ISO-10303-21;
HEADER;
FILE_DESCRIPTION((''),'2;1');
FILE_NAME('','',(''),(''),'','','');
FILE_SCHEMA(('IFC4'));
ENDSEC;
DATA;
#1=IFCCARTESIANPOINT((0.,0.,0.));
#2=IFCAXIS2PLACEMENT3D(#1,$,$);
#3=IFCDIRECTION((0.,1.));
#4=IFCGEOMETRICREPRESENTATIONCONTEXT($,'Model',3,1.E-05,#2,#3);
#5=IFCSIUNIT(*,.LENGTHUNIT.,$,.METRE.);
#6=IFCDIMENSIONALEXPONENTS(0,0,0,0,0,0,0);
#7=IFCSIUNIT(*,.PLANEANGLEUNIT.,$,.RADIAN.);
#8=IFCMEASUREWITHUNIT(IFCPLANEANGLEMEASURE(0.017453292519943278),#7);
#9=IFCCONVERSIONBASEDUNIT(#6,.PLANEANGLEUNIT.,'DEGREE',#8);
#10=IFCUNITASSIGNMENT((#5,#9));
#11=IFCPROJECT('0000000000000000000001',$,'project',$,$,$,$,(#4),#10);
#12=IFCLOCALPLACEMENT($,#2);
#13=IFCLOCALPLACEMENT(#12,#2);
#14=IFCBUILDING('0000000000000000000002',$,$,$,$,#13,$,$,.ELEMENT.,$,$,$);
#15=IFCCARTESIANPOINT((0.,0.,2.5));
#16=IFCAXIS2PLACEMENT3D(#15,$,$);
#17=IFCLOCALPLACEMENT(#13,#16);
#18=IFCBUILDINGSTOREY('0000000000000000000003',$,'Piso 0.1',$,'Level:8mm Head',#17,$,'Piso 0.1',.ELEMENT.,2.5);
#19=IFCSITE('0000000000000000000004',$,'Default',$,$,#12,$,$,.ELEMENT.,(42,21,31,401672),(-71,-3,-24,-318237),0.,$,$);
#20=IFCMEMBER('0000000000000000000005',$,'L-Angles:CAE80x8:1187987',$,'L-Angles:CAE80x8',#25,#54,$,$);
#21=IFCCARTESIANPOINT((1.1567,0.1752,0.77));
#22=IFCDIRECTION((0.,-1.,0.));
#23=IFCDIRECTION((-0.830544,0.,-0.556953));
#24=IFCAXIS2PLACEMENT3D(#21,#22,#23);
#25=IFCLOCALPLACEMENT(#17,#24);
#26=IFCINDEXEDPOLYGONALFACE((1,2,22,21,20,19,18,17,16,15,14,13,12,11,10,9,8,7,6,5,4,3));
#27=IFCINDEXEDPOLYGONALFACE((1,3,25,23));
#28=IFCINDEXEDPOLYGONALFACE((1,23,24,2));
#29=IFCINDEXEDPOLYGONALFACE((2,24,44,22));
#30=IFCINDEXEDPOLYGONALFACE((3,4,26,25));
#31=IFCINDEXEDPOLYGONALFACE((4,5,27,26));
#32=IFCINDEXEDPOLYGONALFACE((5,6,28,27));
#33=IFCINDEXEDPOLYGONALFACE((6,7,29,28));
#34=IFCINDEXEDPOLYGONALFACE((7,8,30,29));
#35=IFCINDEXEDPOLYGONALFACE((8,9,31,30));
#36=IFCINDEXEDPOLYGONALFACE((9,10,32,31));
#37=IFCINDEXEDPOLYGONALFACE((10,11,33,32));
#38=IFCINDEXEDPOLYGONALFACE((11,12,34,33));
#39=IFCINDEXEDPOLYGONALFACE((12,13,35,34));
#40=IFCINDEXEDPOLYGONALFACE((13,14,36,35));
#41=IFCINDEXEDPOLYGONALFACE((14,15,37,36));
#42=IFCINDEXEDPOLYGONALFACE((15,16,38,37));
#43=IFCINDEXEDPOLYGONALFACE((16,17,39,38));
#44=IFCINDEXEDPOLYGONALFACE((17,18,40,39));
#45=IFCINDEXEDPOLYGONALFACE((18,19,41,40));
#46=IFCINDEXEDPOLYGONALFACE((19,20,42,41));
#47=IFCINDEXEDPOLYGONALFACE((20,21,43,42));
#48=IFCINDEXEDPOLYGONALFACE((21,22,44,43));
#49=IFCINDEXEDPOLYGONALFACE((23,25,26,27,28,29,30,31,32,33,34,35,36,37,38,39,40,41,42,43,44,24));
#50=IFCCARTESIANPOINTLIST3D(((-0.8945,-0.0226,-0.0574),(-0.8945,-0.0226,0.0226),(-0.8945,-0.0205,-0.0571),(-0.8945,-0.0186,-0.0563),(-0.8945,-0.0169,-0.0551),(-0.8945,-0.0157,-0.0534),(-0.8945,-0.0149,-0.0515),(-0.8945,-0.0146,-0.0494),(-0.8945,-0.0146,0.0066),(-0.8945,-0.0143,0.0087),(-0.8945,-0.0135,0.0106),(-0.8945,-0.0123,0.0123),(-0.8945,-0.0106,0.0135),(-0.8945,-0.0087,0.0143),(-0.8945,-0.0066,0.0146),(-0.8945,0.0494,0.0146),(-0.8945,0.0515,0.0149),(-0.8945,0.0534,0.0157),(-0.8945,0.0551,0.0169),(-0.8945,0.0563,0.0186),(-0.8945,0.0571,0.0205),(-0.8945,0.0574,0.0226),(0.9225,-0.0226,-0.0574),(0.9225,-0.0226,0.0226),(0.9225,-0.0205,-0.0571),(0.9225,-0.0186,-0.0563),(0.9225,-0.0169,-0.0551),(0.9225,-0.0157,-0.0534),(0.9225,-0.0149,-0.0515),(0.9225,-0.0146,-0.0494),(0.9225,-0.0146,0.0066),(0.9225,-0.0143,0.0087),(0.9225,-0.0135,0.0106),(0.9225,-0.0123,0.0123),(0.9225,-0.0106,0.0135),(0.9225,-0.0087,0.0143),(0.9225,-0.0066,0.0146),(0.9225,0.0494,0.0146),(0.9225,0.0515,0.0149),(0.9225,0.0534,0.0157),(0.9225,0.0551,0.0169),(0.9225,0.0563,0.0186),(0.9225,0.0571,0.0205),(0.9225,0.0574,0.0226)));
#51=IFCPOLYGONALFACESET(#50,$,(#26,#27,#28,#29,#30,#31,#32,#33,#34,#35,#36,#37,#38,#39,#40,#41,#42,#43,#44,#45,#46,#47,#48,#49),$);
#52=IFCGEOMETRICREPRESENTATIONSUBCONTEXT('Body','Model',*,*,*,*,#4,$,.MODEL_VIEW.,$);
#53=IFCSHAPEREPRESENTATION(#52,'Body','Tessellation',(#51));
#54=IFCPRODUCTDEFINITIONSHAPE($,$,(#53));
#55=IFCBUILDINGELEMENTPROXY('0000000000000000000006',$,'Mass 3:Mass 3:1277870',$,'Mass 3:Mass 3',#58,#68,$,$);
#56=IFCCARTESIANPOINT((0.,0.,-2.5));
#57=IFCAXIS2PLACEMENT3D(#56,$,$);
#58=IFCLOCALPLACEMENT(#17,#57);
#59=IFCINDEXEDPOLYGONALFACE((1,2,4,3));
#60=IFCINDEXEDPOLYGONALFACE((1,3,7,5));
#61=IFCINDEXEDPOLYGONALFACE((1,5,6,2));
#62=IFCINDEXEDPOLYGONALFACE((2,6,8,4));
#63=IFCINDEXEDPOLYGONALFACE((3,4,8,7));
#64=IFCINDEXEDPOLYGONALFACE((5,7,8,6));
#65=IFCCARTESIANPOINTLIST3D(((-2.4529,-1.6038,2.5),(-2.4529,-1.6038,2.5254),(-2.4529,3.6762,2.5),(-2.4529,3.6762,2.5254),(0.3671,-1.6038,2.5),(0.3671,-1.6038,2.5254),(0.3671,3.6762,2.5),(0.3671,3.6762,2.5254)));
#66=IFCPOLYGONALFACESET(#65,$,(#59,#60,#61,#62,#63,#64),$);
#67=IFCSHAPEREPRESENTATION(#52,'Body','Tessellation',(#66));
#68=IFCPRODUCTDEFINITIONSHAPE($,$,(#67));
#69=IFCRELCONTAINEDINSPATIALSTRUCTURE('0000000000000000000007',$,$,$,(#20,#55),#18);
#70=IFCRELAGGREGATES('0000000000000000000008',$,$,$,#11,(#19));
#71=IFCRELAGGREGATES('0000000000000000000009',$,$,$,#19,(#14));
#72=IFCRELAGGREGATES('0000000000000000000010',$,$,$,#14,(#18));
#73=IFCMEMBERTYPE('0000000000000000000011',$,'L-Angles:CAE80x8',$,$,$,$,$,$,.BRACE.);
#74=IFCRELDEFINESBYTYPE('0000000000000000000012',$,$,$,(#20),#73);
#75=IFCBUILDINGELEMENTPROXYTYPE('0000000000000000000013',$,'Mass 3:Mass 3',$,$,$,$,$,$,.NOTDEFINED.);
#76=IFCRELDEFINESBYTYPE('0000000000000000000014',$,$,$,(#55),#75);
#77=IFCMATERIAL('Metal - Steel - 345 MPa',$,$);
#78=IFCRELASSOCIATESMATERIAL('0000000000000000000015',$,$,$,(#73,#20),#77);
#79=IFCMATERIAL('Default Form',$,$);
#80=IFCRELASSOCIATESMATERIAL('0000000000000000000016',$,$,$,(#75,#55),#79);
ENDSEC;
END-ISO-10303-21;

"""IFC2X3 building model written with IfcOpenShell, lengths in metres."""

from ifc_helpers import new_model, entity, si_unit, converted_unit, direction, frame, frame_2d, origin, place, context, subcontext, project, spatial, polyline, circle_curve, parameter, trimmed, segment, composite_curve, rectangle, outline, extrude, source, transform, mapped, material, type_object, type_shapes, element, save


model = new_model("IFC2X3")

# Units and contexts
model_context = context("Model", 3, precision=1e-05, world=origin(), true_north=direction((0.0, 1.0)))
body_context = subcontext(model_context, "Body", "Model", "MODEL_VIEW")
ifc_project = project(units=[si_unit("LENGTHUNIT", "METRE"), converted_unit("PLANEANGLEUNIT", "DEGREE", entity("IfcPlaneAngleMeasure", 0.017453292519943278), si_unit("PLANEANGLEUNIT", "RADIAN"), dimensions=[0, 0, 0, 0, 0, 0, 0])], contexts=[model_context])

# Site, building, storey
site_placement = place(None, origin())
site = spatial("IfcSite", under=ifc_project, at=site_placement, Name="Default", CompositionType="ELEMENT", RefLatitude=(42, 21, 31, 401672), RefLongitude=(-71, -3, -24, -318237), RefElevation=0.0)
building_placement = place(site_placement, origin())
building = spatial("IfcBuilding", under=site, at=building_placement, CompositionType="ELEMENT")
storey_placement = place(building_placement, frame((0.0, 0.0, 2.5)))
storey = spatial("IfcBuildingStorey", under=building, at=storey_placement, Name="Piso 0.1", ObjectType="Level:8mm Head", LongName="Piso 0.1", CompositionType="ELEMENT", Elevation=2.5)

# Shared definitions
ifc_material_1 = material(Name="Metal - Steel - 345 MPa")

# Member
member_type_1 = type_object("IfcMemberType", Name="L-Angles:CAE80x8", PredefinedType="BRACE", material=ifc_material_1)
shared_shape_1 = source(origin(), body_context, "Body", "SweptSolid", [
    extrude(outline(composite_curve([segment(polyline([(-0.0263, -0.0263), (0.0537, -0.0263)]), True, "CONTINUOUS"), segment(trimmed(circle_curve(frame_2d((0.0457, -0.0263), x_axis=(0.0, 1.0)), 0.008), [parameter(270.0)], [parameter(0.0)], True, "PARAMETER"), True, "CONTINUOUS"), segment(polyline([(0.0457, -0.0183), (-0.0103, -0.0183)]), True, "CONTINUOUS"), segment(trimmed(circle_curve(frame_2d((-0.0103, -0.0103), x_axis=(0.0, 1.0)), 0.008), [parameter(90.0)], [parameter(180.0)], True, "PARAMETER"), False, "CONTINUOUS"), segment(polyline([(-0.0183, -0.0103), (-0.0183, 0.0457)]), True, "CONTINUOUS"), segment(trimmed(circle_curve(frame_2d((-0.0263, 0.0457), x_axis=(0.0, 1.0)), 0.008), [parameter(270.0)], [parameter(360.0)], True, "PARAMETER"), True, "CONTINUOUS"), segment(polyline([(-0.0263, 0.0537), (-0.0263, -0.0263)]), True, "CONTINUOUS")], self_intersect=False)), frame((-0.8945, 0.0037, -0.0037), z_axis=(1.0, 0.0, 0.0), x_axis=(0.0, 0.0, -1.0)), (0.0, 0.0, 1.0), 1.817),
])
type_shapes(member_type_1, [shared_shape_1])
member_1_placement = place(storey_placement, frame((1.1567, 0.1752, 0.77), z_axis=(0.0, -1.0, 0.0), x_axis=(-0.830544, 0.0, -0.556953)))
element("IfcMember", 1, at=member_1_placement, inside=storey, type_object=member_type_1, material=ifc_material_1, Name="L-Angles:CAE80x8:1187987", ObjectType="L-Angles:CAE80x8", context=body_context, shape_type="MappedRepresentation", body=[
    mapped(shared_shape_1, transform((0.0, 0.0, 0.0), scale=1.0)),
])

# Building element proxy
ifc_material_2 = material(Name="Default Form")
building_element_proxy_type_1 = type_object("IfcBuildingElementProxyType", Name="Mass 3:Mass 3", PredefinedType="NOTDEFINED", material=ifc_material_2)
shared_shape_2 = source(origin(), body_context, "Body", "SweptSolid", [
    extrude(rectangle(XDim=0.0254, YDim=5.28, at=frame_2d((0.0, 0.0), x_axis=(1.0, 0.0))), frame((-2.4529, 1.0362, 2.5127), z_axis=(1.0, 0.0, 0.0), x_axis=(0.0, 0.0, 1.0)), (0.0, 0.0, 1.0), 2.82),
])
type_shapes(building_element_proxy_type_1, [shared_shape_2])
proxy_1_placement = place(storey_placement, frame((0.0, 0.0, -2.5)))
element("IfcBuildingElementProxy", 2, at=proxy_1_placement, inside=storey, type_object=building_element_proxy_type_1, material=ifc_material_2, Name="Mass 3:Mass 3:1277870", ObjectType="Mass 3:Mass 3", context=body_context, shape_type="MappedRepresentation", body=[
    mapped(shared_shape_2, transform((0.0, 0.0, 0.0), scale=1.0)),
])

save(model, "model.ifc")
